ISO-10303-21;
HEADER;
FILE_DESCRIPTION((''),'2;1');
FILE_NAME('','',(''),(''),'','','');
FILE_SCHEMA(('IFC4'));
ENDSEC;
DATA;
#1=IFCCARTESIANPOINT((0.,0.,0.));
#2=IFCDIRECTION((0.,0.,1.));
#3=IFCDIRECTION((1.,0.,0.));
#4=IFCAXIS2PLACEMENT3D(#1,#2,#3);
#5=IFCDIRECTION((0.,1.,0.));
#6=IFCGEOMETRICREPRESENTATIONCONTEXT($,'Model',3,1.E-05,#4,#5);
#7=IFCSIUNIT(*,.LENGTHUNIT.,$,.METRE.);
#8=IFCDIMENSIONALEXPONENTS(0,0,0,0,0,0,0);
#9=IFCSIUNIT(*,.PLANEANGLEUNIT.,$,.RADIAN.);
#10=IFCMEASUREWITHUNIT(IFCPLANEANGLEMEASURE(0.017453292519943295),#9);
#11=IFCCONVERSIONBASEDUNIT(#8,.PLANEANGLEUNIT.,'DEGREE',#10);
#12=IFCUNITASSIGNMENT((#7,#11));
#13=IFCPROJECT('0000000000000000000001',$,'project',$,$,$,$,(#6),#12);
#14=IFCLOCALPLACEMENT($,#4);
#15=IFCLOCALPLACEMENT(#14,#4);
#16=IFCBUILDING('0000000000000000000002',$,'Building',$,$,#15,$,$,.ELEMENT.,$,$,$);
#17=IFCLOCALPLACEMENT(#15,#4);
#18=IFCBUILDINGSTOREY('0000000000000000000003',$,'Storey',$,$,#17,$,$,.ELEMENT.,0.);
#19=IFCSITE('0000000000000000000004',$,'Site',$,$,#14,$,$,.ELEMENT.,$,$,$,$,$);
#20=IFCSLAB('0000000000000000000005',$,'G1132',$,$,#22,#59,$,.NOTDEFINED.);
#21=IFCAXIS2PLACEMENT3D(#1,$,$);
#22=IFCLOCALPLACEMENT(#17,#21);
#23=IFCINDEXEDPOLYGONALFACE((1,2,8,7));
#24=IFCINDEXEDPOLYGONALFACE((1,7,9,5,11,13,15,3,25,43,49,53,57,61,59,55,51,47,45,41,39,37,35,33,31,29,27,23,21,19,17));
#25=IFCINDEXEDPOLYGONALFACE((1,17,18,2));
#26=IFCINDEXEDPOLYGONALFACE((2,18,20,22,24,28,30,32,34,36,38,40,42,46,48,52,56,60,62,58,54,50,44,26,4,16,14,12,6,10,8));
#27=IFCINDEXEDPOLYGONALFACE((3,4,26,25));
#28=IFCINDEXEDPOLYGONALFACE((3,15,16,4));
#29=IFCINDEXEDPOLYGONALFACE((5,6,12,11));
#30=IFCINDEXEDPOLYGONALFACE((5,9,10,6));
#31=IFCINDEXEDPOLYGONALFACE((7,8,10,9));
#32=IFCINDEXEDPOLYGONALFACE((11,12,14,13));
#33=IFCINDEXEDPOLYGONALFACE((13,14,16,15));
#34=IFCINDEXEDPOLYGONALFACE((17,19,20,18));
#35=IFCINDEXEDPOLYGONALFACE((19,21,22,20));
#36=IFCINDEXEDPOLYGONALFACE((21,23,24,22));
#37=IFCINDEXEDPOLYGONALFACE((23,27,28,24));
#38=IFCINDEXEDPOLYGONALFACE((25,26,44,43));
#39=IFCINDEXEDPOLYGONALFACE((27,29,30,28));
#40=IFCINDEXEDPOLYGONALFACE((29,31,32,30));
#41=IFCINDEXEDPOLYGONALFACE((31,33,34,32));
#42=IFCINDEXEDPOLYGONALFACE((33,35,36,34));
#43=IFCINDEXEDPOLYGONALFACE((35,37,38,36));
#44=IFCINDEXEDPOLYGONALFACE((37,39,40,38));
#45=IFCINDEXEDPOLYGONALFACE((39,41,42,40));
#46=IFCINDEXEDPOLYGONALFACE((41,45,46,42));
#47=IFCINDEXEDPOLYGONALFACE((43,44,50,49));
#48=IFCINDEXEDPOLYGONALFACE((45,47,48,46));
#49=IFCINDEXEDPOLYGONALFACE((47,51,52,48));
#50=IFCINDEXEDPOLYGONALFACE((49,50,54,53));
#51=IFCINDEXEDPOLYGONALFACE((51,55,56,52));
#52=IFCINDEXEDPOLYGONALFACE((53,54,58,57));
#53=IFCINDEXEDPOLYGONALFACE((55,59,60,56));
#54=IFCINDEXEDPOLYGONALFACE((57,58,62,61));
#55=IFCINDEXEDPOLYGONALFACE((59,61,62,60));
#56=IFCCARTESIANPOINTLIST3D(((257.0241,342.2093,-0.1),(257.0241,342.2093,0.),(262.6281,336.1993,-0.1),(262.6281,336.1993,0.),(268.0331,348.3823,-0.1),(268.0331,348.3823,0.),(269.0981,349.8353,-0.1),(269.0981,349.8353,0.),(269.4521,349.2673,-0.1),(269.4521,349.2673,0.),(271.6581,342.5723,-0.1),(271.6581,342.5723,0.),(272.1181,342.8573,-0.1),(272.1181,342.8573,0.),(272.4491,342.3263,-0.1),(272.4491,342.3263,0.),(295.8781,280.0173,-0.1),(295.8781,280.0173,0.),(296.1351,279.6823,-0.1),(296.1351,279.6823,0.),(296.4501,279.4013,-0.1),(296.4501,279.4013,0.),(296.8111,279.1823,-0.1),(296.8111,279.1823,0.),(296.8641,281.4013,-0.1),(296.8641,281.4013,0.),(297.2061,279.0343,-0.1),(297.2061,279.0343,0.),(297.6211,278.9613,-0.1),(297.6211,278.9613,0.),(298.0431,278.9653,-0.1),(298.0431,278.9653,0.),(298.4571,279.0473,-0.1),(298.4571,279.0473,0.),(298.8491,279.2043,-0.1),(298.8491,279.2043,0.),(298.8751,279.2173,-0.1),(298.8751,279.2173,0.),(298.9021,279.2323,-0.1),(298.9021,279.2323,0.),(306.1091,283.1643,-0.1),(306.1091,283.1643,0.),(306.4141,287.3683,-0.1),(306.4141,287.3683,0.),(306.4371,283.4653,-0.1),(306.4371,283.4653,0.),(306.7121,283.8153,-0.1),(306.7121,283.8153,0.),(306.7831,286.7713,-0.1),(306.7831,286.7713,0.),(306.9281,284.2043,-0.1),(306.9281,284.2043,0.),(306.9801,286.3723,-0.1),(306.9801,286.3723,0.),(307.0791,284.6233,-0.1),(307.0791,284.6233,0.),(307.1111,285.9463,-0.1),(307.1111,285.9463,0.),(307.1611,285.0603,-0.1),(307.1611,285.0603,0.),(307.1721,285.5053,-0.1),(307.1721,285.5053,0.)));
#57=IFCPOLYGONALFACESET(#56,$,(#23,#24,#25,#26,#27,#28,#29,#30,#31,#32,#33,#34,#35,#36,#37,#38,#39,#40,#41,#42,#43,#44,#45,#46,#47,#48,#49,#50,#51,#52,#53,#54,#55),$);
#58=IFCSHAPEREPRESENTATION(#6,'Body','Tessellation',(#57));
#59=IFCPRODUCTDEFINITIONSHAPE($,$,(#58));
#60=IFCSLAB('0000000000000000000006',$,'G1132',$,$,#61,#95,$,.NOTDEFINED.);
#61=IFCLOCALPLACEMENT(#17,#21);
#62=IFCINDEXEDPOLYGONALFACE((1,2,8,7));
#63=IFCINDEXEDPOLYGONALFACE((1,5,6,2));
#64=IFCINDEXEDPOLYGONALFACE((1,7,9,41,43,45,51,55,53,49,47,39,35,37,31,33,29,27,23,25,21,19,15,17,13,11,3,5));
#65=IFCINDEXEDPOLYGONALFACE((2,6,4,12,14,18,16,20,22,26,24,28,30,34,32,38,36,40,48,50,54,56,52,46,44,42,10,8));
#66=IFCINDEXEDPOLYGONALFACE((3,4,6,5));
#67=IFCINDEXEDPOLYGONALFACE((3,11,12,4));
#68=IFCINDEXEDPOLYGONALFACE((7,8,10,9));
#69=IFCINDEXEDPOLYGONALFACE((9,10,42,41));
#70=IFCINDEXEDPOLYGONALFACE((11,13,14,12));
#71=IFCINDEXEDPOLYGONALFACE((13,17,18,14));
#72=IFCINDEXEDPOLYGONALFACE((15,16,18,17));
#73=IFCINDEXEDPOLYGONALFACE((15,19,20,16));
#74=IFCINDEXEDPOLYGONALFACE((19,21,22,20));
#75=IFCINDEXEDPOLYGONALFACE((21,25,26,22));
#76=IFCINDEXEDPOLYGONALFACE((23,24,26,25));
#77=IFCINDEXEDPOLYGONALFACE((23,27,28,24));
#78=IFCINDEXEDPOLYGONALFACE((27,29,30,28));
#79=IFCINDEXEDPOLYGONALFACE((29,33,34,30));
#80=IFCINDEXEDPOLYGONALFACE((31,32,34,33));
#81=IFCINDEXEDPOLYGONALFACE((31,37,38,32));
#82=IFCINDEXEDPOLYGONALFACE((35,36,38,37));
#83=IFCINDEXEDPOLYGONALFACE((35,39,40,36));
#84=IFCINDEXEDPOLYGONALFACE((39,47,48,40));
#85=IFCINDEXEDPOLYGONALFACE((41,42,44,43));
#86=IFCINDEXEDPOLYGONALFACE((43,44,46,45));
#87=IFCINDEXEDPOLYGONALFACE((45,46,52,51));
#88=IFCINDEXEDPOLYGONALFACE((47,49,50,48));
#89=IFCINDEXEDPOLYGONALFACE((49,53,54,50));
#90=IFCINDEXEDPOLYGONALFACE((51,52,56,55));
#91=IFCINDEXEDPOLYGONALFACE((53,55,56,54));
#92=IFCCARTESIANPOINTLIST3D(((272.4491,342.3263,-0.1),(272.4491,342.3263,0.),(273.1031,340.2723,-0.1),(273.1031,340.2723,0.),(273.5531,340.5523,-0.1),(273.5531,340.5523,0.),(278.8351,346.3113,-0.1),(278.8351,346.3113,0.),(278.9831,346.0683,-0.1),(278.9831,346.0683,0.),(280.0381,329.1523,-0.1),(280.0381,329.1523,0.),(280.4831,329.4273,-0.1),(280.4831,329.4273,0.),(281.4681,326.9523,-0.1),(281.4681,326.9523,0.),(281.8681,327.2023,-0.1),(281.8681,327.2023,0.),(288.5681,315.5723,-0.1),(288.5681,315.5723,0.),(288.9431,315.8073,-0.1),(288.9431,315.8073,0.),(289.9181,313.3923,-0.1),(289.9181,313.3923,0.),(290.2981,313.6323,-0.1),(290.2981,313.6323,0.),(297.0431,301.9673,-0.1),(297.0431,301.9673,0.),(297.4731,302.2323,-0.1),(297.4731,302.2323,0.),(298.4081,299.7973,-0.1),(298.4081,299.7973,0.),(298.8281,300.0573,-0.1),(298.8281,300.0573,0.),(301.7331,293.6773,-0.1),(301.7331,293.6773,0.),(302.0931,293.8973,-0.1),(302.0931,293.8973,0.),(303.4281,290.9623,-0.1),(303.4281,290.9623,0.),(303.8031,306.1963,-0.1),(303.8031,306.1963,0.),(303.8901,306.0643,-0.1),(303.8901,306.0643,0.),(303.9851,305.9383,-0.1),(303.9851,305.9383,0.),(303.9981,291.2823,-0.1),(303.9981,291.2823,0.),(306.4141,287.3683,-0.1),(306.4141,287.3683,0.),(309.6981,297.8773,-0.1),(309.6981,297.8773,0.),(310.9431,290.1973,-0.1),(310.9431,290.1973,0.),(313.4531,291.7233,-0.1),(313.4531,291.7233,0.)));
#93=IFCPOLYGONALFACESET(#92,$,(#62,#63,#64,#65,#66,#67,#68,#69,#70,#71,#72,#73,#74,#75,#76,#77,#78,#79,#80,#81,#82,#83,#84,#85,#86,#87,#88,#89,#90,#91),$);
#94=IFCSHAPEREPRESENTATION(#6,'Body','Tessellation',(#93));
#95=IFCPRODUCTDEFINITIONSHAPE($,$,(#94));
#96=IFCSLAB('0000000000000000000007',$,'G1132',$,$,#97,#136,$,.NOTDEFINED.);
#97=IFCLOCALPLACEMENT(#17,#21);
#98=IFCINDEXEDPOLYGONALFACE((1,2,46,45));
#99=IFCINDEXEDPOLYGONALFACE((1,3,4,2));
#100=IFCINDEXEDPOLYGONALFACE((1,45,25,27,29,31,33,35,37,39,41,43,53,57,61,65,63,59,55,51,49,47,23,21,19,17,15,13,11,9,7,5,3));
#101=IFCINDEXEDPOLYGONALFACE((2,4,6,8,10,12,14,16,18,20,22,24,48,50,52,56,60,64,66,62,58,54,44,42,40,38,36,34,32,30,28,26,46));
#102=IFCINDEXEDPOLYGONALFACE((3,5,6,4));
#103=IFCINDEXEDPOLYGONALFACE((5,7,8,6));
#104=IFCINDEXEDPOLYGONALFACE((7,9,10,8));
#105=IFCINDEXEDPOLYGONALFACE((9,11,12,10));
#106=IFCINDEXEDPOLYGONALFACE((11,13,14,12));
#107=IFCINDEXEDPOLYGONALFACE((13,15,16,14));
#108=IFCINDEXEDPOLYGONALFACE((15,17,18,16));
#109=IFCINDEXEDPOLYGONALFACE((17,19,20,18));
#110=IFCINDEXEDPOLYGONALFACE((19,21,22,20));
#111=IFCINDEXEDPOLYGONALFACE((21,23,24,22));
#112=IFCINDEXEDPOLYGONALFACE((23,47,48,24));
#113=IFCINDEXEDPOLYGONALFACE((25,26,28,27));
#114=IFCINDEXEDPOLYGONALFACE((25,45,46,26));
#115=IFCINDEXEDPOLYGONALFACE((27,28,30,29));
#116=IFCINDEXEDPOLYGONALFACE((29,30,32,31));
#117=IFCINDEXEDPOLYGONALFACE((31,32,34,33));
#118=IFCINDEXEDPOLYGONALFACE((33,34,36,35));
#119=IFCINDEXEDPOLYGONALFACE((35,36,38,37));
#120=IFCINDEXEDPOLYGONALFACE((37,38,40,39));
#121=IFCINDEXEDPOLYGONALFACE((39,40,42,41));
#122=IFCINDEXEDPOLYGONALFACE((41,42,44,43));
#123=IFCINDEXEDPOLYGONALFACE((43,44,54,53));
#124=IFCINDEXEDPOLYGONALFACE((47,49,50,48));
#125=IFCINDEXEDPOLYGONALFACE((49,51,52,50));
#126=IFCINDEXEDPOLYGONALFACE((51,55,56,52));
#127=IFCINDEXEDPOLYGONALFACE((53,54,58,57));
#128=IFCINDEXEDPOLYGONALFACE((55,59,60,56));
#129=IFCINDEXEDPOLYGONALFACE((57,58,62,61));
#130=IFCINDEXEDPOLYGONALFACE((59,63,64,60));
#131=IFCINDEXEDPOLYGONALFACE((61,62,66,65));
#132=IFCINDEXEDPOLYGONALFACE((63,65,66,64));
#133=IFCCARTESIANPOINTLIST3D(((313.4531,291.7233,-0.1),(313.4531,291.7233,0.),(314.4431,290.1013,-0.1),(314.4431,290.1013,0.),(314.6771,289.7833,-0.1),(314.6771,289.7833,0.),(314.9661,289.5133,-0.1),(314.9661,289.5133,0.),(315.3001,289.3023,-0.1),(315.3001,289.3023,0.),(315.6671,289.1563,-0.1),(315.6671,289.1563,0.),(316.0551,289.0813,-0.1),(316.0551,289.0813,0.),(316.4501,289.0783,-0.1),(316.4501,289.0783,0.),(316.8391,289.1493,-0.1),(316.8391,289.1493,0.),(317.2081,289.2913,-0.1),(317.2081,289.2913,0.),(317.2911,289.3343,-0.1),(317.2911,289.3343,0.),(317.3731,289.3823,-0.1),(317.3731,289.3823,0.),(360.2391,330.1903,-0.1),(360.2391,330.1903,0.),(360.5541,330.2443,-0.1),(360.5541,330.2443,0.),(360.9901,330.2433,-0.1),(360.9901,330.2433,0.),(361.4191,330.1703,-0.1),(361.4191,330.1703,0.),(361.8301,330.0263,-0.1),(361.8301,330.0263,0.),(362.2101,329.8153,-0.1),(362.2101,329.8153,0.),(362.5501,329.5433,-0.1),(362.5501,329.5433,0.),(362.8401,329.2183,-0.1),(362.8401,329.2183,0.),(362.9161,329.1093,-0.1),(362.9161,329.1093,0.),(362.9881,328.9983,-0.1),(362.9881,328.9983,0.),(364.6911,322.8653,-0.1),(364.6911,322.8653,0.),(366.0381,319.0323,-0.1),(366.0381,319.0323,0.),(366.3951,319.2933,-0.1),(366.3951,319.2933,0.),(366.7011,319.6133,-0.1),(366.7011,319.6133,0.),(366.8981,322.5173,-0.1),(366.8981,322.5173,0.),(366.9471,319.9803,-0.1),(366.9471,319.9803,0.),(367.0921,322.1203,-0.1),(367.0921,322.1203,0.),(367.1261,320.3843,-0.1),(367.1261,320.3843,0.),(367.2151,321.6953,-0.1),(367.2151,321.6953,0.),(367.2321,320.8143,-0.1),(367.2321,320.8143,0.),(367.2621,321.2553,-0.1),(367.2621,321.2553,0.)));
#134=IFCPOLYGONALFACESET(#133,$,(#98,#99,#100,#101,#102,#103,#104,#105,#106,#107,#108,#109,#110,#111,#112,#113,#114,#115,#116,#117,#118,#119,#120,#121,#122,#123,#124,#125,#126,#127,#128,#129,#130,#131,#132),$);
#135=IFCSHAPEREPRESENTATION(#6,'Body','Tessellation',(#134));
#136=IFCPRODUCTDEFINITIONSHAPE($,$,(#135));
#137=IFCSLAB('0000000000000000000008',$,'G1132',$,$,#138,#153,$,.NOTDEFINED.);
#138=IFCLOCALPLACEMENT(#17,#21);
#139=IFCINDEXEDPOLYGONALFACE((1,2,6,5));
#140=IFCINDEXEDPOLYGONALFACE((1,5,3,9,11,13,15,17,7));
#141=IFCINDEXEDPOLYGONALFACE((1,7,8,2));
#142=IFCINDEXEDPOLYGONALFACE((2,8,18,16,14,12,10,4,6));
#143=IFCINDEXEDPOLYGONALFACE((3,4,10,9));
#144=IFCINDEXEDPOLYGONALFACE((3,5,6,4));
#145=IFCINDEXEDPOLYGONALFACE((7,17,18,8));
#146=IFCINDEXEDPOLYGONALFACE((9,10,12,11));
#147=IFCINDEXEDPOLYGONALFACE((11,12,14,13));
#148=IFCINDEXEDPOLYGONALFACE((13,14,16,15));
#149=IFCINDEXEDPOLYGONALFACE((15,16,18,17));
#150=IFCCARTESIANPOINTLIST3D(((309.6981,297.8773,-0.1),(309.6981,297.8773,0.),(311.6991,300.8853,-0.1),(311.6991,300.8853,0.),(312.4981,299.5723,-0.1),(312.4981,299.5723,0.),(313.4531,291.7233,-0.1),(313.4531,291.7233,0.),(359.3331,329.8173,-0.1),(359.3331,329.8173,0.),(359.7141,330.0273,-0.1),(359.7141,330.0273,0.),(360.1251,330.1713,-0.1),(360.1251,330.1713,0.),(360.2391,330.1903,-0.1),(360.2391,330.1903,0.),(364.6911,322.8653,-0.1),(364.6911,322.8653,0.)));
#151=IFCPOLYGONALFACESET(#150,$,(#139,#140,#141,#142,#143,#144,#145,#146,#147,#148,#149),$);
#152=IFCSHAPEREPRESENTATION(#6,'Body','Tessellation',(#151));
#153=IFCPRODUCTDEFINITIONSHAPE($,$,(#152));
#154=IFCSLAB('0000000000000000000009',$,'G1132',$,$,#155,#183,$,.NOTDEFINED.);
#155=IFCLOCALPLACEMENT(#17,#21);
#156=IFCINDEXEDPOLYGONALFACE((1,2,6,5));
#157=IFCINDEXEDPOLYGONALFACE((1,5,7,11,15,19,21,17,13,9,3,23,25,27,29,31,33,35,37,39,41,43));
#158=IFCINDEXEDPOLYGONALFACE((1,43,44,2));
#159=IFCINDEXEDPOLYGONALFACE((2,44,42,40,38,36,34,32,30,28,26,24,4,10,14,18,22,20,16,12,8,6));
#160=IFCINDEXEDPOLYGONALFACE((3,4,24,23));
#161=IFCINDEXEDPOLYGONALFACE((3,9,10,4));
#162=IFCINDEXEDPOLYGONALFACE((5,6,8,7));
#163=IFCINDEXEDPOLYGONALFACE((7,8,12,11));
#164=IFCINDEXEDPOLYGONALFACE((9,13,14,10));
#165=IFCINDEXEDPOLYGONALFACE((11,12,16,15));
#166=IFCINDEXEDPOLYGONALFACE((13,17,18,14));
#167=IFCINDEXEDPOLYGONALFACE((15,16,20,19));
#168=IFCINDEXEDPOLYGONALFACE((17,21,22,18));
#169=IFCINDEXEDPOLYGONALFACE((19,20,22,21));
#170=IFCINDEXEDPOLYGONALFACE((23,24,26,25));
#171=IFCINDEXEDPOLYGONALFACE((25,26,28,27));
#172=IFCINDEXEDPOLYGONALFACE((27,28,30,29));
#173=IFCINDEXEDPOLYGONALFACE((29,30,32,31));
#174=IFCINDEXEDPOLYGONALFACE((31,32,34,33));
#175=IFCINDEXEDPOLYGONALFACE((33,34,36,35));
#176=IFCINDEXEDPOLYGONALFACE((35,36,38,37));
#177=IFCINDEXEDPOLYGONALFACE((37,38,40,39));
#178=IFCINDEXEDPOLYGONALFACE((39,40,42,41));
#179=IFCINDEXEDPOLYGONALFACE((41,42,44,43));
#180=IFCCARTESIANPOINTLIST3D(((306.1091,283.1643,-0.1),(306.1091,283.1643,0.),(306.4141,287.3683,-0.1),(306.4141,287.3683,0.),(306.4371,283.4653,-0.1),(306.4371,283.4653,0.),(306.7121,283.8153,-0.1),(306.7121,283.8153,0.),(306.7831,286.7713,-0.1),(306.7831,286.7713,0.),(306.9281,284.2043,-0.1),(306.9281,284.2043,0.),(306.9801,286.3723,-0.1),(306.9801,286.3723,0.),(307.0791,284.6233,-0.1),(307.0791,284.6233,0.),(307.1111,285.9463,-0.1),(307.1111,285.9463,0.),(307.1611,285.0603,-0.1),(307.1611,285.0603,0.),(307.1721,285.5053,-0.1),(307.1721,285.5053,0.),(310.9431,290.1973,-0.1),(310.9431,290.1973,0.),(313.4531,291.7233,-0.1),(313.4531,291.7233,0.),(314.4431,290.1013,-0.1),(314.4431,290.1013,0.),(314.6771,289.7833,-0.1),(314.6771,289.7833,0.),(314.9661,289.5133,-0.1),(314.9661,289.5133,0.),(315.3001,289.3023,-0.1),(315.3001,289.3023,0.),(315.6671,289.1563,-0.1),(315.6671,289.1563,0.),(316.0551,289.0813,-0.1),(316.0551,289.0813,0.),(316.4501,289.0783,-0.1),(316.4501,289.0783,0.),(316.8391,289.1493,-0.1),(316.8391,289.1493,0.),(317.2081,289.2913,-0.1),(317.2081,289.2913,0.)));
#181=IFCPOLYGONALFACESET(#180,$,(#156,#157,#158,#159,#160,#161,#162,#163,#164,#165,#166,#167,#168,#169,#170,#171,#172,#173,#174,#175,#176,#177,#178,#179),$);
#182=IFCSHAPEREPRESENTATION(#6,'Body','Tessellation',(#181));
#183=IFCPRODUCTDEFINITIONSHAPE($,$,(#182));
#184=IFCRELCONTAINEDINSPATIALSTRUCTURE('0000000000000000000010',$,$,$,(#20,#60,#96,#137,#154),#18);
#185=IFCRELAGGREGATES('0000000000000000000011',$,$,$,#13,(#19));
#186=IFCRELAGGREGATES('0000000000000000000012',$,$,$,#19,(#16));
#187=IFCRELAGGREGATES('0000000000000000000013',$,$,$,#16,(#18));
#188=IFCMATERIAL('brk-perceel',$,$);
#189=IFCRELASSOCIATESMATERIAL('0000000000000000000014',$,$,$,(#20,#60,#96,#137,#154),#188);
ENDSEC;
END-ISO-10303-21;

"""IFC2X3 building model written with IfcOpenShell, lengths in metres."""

from ifc_helpers import new_model, entity, si_unit, converted_unit, direction, frame, origin_with_axes, place, context, project, spatial, polyline, outline, extrude, material, element, save


model = new_model("IFC2X3")

# Units and contexts
model_context = context("Model", 3, precision=1e-05, world=origin_with_axes(), true_north=direction((0.0, 1.0, 0.0)))
ifc_project = project(units=[si_unit("LENGTHUNIT", "METRE"), converted_unit("PLANEANGLEUNIT", "DEGREE", entity("IfcPlaneAngleMeasure", 0.017453292519943295), si_unit("PLANEANGLEUNIT", "RADIAN"), dimensions=[0, 0, 0, 0, 0, 0, 0])], contexts=[model_context])

# Site, building, storey
site_placement = place(None, origin_with_axes())
site = spatial("IfcSite", under=ifc_project, at=site_placement, Name="Site", CompositionType="ELEMENT")
building_placement = place(site_placement, origin_with_axes())
building = spatial("IfcBuilding", under=site, at=building_placement, Name="Building", CompositionType="ELEMENT")
storey_placement = place(building_placement, origin_with_axes())
storey = spatial("IfcBuildingStorey", under=building, at=storey_placement, Name="Storey", CompositionType="ELEMENT", Elevation=0.0)

# Slabs
ifc_material = material(Name="brk-perceel")
slab_1_placement = place(storey_placement, frame((0.0, 0.0, -0.1), z_axis=(0.0, 0.0, 1.0), x_axis=(1.0, 0.0, 0.0)))
element("IfcSlab", 1, at=slab_1_placement, inside=storey, material=ifc_material, Name="G1132", PredefinedType="NOTDEFINED", context=model_context, shape_type="SweptSolid", body=[
    extrude(outline(polyline([(298.4571, 279.0473), (298.0431, 278.9653), (297.6211, 278.9613), (297.2061, 279.0343), (296.8111, 279.1823), (296.4501, 279.4013), (296.1351, 279.6823), (295.8781, 280.0173), (257.0241, 342.2093), (269.0981, 349.8353), (269.4521, 349.2673), (268.0331, 348.3823), (271.6581, 342.5723), (272.1181, 342.8573), (272.4491, 342.3263), (262.6281, 336.1993), (296.8641, 281.4013), (306.4141, 287.3683), (306.7831, 286.7713), (306.9801, 286.3723), (307.1111, 285.9463), (307.1721, 285.5053), (307.1611, 285.0603), (307.0791, 284.6233), (306.9281, 284.2043), (306.7121, 283.8153), (306.4371, 283.4653), (306.1091, 283.1643), (298.9021, 279.2323), (298.8751, 279.2173), (298.8491, 279.2043), (298.4571, 279.0473)])), origin_with_axes(), (0.0, 0.0, 1.0), 0.1),
])
slab_2_placement = place(storey_placement, frame((0.0, 0.0, -0.1), z_axis=(0.0, 0.0, 1.0), x_axis=(1.0, 0.0, 0.0)))
element("IfcSlab", 2, at=slab_2_placement, inside=storey, material=ifc_material, Name="G1132", PredefinedType="NOTDEFINED", context=model_context, shape_type="SweptSolid", body=[
    extrude(outline(polyline([(303.9981, 291.2823), (303.4281, 290.9623), (301.7331, 293.6773), (302.0931, 293.8973), (298.4081, 299.7973), (298.8281, 300.0573), (297.4731, 302.2323), (297.0431, 301.9673), (289.9181, 313.3923), (290.2981, 313.6323), (288.9431, 315.8073), (288.5681, 315.5723), (281.4681, 326.9523), (281.8681, 327.2023), (280.4831, 329.4273), (280.0381, 329.1523), (273.1031, 340.2723), (273.5531, 340.5523), (272.4491, 342.3263), (278.8351, 346.3113), (278.9831, 346.0683), (303.8031, 306.1963), (303.8901, 306.0643), (303.9851, 305.9383), (309.6981, 297.8773), (313.4531, 291.7233), (310.9431, 290.1973), (306.4141, 287.3683), (303.9981, 291.2823)])), origin_with_axes(), (0.0, 0.0, 1.0), 0.1),
])
slab_3_placement = place(storey_placement, frame((0.0, 0.0, -0.1), z_axis=(0.0, 0.0, 1.0), x_axis=(1.0, 0.0, 0.0)))
element("IfcSlab", 3, at=slab_3_placement, inside=storey, material=ifc_material, Name="G1132", PredefinedType="NOTDEFINED", context=model_context, shape_type="SweptSolid", body=[
    extrude(outline(polyline([(316.8391, 289.1493), (316.4501, 289.0783), (316.0551, 289.0813), (315.6671, 289.1563), (315.3001, 289.3023), (314.9661, 289.5133), (314.6771, 289.7833), (314.4431, 290.1013), (313.4531, 291.7233), (364.6911, 322.8653), (360.2391, 330.1903), (360.5541, 330.2443), (360.9901, 330.2433), (361.4191, 330.1703), (361.8301, 330.0263), (362.2101, 329.8153), (362.5501, 329.5433), (362.8401, 329.2183), (362.9161, 329.1093), (362.9881, 328.9983), (366.8981, 322.5173), (367.0921, 322.1203), (367.2151, 321.6953), (367.2621, 321.2553), (367.2321, 320.8143), (367.1261, 320.3843), (366.9471, 319.9803), (366.7011, 319.6133), (366.3951, 319.2933), (366.0381, 319.0323), (317.3731, 289.3823), (317.2911, 289.3343), (317.2081, 289.2913), (316.8391, 289.1493)])), origin_with_axes(), (0.0, 0.0, 1.0), 0.1),
])
slab_4_placement = place(storey_placement, frame((0.0, 0.0, -0.1), z_axis=(0.0, 0.0, 1.0), x_axis=(1.0, 0.0, 0.0)))
element("IfcSlab", 4, at=slab_4_placement, inside=storey, material=ifc_material, Name="G1132", PredefinedType="NOTDEFINED", context=model_context, shape_type="SweptSolid", body=[
    extrude(outline(polyline([(312.4981, 299.5723), (311.6991, 300.8853), (359.3331, 329.8173), (359.7141, 330.0273), (360.1251, 330.1713), (360.2391, 330.1903), (364.6911, 322.8653), (313.4531, 291.7233), (309.6981, 297.8773), (312.4981, 299.5723)])), origin_with_axes(), (0.0, 0.0, 1.0), 0.1),
])
slab_5_placement = place(storey_placement, frame((0.0, 0.0, -0.1), z_axis=(0.0, 0.0, 1.0), x_axis=(1.0, 0.0, 0.0)))
element("IfcSlab", 5, at=slab_5_placement, inside=storey, material=ifc_material, Name="G1132", PredefinedType="NOTDEFINED", context=model_context, shape_type="SweptSolid", body=[
    extrude(outline(polyline([(306.4141, 287.3683), (310.9431, 290.1973), (313.4531, 291.7233), (314.4431, 290.1013), (314.6771, 289.7833), (314.9661, 289.5133), (315.3001, 289.3023), (315.6671, 289.1563), (316.0551, 289.0813), (316.4501, 289.0783), (316.8391, 289.1493), (317.2081, 289.2913), (306.1091, 283.1643), (306.4371, 283.4653), (306.7121, 283.8153), (306.9281, 284.2043), (307.0791, 284.6233), (307.1611, 285.0603), (307.1721, 285.5053), (307.1111, 285.9463), (306.9801, 286.3723), (306.7831, 286.7713), (306.4141, 287.3683)])), origin_with_axes(), (0.0, 0.0, 1.0), 0.1),
])

save(model, "model.ifc")
